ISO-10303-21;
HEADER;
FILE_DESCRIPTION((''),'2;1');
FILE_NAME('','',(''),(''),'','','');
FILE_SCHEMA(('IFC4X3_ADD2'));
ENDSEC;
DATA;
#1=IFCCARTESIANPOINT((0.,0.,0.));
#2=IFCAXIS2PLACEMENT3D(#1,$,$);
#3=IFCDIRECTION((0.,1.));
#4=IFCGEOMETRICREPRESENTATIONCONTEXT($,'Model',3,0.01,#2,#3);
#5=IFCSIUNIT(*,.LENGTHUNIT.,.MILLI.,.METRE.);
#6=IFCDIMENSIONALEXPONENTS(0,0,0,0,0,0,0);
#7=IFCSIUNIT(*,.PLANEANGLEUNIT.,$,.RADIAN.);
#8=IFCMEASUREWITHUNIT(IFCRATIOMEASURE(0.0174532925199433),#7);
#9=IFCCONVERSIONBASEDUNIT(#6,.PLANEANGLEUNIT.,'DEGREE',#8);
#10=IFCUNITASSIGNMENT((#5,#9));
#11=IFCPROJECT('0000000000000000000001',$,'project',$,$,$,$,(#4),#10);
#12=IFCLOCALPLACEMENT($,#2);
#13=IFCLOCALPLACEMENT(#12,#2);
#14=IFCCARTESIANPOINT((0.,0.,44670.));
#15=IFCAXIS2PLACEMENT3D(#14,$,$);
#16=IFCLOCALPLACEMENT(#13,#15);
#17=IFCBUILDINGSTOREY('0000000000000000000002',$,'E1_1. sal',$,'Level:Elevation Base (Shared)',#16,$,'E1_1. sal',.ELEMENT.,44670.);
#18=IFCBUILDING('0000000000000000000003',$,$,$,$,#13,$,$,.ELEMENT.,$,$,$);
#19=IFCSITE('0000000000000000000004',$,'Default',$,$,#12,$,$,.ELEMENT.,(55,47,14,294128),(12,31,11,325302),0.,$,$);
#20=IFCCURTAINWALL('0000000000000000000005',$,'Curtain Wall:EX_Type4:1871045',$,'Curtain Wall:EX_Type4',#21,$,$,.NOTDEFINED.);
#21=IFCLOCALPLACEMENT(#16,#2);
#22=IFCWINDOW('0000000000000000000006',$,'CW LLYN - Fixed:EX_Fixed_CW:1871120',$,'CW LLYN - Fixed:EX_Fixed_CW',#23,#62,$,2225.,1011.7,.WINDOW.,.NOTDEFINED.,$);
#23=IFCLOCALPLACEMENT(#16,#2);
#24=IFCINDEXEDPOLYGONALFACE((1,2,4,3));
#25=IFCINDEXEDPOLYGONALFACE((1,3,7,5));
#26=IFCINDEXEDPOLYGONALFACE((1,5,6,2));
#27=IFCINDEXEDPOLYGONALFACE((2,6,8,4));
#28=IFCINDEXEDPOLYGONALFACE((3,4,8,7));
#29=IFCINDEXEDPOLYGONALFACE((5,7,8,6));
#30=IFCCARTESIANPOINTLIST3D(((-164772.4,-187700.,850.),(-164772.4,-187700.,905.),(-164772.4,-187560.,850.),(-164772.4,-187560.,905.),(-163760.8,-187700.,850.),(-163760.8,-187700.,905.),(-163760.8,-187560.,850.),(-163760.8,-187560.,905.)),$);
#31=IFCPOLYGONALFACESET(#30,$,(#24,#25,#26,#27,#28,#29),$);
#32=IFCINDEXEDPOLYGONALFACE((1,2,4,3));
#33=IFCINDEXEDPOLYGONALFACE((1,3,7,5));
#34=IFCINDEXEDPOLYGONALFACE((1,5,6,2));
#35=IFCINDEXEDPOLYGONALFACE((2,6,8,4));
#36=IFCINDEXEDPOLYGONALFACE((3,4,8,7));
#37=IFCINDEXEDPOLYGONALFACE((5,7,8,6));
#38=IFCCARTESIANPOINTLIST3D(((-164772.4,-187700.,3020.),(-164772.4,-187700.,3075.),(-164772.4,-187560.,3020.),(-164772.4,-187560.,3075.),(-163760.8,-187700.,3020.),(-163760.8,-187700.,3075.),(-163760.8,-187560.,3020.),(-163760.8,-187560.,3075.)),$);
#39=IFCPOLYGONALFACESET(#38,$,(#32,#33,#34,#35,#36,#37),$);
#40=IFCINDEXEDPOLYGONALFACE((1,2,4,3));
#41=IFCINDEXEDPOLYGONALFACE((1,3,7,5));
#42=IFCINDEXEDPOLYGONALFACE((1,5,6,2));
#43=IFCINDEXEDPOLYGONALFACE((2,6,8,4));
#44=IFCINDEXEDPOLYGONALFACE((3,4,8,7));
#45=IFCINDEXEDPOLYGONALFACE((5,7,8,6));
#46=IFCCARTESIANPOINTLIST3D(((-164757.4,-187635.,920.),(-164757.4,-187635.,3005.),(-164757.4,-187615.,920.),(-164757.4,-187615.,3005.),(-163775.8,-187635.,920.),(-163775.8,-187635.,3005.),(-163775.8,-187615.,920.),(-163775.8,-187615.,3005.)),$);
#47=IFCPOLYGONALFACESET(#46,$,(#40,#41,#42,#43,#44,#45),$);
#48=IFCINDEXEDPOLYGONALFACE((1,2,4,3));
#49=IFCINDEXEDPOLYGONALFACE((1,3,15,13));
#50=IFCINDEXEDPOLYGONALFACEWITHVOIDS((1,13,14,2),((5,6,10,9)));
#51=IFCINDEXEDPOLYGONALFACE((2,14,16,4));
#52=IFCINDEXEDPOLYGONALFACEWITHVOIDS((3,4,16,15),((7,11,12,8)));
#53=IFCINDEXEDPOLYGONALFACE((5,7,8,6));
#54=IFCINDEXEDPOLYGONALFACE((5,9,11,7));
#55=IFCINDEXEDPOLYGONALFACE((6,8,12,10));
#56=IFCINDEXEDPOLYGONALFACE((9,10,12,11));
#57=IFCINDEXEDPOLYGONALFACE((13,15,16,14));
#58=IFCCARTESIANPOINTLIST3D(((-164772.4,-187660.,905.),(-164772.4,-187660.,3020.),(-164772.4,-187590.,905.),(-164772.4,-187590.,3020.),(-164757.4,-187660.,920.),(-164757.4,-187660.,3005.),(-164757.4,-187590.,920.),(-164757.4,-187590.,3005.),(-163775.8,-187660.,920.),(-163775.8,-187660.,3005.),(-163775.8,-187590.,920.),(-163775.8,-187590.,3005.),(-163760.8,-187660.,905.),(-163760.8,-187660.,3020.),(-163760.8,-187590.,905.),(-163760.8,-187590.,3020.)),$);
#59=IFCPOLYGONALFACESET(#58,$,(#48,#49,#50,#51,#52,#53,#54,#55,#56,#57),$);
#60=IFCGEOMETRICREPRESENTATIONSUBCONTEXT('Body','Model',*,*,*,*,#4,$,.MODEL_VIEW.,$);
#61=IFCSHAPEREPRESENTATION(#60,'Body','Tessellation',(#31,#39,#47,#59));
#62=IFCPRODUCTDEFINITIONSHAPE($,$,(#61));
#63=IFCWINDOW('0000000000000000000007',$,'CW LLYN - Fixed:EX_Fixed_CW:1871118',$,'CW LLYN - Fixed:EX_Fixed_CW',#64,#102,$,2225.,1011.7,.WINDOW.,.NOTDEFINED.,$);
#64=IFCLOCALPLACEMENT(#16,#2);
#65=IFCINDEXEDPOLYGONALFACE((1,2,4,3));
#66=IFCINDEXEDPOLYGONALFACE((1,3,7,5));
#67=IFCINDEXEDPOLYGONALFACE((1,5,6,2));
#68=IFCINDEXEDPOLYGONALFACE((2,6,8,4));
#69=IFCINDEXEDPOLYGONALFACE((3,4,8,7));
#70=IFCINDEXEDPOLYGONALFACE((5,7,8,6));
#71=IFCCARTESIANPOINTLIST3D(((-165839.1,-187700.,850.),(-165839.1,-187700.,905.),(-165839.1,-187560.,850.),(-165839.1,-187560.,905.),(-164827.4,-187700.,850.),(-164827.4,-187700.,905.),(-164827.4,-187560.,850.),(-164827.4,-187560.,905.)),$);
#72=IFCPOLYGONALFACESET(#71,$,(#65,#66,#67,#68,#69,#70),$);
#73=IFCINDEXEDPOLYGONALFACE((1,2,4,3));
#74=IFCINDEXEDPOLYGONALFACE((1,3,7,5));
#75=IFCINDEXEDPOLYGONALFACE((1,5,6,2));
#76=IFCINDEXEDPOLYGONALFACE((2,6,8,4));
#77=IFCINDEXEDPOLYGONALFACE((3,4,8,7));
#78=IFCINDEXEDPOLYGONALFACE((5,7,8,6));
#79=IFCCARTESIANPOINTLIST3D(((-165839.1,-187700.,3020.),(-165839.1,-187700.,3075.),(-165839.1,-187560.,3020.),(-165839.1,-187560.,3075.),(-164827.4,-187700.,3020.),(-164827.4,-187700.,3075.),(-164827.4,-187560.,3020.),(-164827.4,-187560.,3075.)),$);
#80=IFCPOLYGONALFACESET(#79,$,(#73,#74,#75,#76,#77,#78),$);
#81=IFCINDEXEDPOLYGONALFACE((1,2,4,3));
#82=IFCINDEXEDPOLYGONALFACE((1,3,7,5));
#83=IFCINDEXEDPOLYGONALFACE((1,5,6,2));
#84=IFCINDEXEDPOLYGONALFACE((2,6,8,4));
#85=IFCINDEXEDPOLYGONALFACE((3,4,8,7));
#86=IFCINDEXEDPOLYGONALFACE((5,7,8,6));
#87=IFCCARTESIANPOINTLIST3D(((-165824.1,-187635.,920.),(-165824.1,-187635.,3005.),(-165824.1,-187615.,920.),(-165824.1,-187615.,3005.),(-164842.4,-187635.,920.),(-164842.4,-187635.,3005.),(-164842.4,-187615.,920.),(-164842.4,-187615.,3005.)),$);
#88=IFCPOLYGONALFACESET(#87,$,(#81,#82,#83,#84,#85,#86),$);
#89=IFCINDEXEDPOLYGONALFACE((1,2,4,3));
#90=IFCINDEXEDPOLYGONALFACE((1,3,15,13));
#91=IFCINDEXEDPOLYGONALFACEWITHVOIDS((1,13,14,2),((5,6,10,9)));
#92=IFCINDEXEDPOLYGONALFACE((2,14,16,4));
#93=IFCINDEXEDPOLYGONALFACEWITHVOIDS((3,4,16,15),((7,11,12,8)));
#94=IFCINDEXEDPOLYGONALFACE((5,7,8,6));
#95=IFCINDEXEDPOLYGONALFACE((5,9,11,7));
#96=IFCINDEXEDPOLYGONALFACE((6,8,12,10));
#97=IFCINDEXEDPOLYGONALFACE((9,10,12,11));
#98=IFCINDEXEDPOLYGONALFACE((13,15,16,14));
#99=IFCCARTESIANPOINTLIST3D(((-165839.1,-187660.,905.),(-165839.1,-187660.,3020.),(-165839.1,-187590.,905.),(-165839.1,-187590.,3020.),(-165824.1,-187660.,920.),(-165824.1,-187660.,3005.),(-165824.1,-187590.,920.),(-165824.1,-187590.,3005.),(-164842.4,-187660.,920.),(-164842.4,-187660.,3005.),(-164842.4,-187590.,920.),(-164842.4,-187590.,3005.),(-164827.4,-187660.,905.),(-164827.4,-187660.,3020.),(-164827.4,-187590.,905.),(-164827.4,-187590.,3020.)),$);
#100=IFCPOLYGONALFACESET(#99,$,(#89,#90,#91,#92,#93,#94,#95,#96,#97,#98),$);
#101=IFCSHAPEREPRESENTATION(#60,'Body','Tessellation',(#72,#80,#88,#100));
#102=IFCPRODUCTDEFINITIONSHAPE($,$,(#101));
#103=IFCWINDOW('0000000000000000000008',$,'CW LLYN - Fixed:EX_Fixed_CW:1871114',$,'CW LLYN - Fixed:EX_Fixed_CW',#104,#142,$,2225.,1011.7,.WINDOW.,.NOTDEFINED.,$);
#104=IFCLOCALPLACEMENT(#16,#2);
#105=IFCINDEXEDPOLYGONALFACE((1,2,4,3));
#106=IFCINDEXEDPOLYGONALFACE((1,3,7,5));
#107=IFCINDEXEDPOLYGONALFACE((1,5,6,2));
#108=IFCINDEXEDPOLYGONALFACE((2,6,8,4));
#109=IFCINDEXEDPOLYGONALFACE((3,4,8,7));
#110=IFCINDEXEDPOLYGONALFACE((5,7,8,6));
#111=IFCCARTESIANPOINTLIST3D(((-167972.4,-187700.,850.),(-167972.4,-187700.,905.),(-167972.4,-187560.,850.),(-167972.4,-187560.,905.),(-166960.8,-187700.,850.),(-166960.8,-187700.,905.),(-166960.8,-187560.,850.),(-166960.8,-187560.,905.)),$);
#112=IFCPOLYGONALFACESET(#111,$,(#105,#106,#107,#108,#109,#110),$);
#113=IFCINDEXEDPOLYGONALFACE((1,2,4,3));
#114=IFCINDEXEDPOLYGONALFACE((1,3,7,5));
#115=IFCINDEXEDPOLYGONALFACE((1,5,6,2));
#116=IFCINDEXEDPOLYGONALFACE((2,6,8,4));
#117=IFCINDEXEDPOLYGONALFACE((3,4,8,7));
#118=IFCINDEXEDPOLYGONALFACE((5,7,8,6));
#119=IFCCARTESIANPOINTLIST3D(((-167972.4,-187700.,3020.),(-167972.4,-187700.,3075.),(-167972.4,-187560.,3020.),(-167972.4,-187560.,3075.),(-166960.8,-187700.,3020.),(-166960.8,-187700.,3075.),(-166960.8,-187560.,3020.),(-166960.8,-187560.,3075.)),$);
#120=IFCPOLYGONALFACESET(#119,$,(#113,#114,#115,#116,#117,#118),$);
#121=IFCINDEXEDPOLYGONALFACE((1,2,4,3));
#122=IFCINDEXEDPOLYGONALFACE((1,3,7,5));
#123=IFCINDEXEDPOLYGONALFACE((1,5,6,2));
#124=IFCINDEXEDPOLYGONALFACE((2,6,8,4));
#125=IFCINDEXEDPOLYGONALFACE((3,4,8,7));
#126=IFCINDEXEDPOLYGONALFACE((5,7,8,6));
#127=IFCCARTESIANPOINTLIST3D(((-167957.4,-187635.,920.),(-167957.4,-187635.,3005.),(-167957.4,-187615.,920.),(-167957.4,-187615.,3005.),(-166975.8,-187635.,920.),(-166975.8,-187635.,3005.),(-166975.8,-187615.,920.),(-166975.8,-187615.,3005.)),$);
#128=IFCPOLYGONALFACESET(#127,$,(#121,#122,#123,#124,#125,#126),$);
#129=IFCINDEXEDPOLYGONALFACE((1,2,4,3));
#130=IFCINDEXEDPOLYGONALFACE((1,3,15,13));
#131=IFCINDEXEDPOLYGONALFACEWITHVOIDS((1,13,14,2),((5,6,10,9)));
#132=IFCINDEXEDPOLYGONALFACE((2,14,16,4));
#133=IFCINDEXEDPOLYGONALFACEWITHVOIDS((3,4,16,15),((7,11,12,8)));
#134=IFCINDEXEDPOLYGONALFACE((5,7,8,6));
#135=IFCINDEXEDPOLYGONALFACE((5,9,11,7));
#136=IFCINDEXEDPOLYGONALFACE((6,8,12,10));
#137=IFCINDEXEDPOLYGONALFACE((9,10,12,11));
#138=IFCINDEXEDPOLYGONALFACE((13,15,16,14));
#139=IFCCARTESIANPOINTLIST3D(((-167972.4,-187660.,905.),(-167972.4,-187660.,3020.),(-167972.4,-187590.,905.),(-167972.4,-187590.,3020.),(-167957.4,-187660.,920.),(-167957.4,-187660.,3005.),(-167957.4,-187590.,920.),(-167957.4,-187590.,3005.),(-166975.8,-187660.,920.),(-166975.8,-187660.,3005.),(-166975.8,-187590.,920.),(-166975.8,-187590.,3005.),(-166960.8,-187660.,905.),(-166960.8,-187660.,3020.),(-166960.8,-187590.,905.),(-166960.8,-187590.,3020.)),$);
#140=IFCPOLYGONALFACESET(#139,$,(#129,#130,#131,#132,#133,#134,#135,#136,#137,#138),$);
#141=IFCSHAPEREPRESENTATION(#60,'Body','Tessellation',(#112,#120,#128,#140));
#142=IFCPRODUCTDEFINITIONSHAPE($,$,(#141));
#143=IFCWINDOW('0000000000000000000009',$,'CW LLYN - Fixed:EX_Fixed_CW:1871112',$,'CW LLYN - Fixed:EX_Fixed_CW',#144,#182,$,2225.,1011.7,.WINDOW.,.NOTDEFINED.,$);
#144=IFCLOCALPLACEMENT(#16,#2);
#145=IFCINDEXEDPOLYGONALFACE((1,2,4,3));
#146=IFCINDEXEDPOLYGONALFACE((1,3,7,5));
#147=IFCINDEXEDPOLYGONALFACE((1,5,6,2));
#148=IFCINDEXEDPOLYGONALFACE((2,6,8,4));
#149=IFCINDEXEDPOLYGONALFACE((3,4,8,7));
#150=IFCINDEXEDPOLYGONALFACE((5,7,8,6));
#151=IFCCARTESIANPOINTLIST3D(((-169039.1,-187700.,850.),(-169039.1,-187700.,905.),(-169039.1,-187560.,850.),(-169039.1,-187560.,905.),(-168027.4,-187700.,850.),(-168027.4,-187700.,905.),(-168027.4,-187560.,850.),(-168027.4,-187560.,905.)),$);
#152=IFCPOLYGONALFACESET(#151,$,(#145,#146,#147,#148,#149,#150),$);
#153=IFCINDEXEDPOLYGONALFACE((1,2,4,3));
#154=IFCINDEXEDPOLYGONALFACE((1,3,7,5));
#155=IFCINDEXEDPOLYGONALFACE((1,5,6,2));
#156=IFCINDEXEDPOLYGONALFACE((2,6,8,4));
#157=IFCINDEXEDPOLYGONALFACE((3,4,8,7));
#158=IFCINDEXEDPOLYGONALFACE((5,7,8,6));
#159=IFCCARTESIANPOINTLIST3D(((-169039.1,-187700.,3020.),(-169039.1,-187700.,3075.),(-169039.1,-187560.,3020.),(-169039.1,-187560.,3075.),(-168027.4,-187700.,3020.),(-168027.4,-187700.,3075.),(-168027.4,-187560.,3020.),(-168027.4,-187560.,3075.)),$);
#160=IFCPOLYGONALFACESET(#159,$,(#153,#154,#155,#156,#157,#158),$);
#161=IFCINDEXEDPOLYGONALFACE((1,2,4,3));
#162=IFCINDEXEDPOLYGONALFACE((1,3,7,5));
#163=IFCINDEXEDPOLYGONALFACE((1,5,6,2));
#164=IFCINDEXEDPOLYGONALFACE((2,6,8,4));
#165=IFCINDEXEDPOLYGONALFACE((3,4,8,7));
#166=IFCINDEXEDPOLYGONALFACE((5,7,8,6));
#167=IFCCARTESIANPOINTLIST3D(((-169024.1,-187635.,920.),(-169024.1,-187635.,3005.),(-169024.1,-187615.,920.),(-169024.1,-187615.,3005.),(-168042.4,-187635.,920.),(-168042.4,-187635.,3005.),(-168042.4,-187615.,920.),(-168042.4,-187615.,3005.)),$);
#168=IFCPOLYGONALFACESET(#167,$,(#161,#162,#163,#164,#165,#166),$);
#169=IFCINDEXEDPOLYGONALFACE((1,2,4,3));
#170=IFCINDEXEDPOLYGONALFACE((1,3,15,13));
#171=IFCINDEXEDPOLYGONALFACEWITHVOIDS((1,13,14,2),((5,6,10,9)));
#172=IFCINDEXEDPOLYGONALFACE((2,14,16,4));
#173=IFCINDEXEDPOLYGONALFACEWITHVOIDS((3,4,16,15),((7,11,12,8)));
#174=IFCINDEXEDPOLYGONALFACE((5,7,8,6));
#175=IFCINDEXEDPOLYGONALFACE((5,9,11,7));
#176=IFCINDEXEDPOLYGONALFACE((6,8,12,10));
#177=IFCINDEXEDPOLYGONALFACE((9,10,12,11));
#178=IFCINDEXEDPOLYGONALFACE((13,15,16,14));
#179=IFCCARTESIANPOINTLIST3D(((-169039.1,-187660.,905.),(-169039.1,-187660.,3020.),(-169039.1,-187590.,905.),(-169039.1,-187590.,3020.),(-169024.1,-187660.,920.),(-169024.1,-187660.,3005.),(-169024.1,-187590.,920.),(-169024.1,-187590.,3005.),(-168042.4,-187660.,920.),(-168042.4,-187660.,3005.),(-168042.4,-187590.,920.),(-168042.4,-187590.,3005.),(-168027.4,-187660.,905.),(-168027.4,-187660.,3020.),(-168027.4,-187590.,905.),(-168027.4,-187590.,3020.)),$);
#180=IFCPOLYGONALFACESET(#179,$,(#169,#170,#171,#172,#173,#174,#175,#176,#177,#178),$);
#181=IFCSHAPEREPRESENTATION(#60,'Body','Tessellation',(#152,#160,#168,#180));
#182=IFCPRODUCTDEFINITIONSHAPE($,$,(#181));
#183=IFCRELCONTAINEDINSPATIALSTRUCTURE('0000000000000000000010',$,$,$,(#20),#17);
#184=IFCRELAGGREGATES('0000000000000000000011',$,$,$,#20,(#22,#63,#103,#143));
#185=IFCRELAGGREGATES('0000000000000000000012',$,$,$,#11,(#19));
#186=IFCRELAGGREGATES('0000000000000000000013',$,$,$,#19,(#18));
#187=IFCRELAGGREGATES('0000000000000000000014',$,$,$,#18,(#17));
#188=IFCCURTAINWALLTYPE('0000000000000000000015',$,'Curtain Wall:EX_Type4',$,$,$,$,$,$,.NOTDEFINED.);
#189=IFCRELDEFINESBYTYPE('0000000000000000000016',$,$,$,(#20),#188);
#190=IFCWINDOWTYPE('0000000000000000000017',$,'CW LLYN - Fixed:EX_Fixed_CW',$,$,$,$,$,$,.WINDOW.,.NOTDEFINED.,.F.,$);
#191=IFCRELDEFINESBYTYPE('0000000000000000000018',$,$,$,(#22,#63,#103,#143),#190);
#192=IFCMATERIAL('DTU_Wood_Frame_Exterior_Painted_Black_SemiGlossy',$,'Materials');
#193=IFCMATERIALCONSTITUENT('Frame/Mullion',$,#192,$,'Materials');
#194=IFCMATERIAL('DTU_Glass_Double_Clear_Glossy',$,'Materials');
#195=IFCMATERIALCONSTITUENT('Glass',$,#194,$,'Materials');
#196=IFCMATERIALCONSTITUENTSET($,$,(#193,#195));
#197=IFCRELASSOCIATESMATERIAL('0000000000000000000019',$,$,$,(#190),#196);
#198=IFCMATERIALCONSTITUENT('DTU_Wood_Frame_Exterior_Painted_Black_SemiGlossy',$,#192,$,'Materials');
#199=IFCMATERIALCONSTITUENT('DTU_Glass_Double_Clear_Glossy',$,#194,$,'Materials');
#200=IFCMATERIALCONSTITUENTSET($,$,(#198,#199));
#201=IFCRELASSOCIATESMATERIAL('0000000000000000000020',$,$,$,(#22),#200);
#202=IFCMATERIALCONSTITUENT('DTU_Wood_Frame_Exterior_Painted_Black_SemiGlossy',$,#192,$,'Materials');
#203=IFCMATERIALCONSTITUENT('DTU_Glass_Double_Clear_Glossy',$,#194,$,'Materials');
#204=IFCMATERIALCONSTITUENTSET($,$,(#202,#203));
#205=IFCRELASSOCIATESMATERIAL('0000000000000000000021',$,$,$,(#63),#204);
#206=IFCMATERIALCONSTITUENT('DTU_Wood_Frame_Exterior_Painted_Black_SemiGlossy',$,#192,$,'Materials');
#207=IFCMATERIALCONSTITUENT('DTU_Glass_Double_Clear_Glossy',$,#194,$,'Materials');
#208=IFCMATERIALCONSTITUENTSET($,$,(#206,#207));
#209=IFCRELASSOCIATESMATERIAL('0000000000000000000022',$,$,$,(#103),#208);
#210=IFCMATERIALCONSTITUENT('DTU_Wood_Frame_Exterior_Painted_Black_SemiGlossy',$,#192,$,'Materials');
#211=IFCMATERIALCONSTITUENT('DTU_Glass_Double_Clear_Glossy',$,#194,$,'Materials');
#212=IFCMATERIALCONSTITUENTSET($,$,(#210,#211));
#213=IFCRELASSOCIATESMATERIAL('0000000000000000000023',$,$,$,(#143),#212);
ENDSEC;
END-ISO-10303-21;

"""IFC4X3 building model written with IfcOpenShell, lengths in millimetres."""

from ifc_helpers import new_model, entity, si_unit, converted_unit, direction, frame, frame_2d, origin, origin_2d_with_axis, place, context, subcontext, project, spatial, polyline, rectangle, outline, extrude, source, transform, mapped, material, constituent, constituent_set, type_object, type_shapes, element, aggregate, save


model = new_model("IFC4X3")

# Units and contexts
model_context = context("Model", 3, precision=0.01, world=origin(), true_north=direction((0.0, 1.0)))
body_context = subcontext(model_context, "Body", "Model", "MODEL_VIEW")
ifc_project = project(units=[si_unit("LENGTHUNIT", "METRE", prefix="MILLI"), converted_unit("PLANEANGLEUNIT", "DEGREE", entity("IfcRatioMeasure", 0.0174532925199433), si_unit("PLANEANGLEUNIT", "RADIAN"), dimensions=[0, 0, 0, 0, 0, 0, 0])], contexts=[model_context])

# Site, building, storey
site_placement = place(None, origin())
site = spatial("IfcSite", under=ifc_project, at=site_placement, Name="Default", CompositionType="ELEMENT", RefLatitude=(55, 47, 14, 294128), RefLongitude=(12, 31, 11, 325302), RefElevation=0.0)
building_placement = place(site_placement, origin())
building = spatial("IfcBuilding", under=site, at=building_placement, CompositionType="ELEMENT")
storey_placement = place(building_placement, frame((0.0, 0.0, 44670.0)))
storey = spatial("IfcBuildingStorey", under=building, at=storey_placement, Name="E1_1. sal", ObjectType="Level:Elevation Base (Shared)", LongName="E1_1. sal", CompositionType="ELEMENT", Elevation=44670.0)

# Curtain wall
curtain_wall_type = type_object("IfcCurtainWallType", Name="Curtain Wall:EX_Type4", PredefinedType="NOTDEFINED")
curtain_wall_placement = place(storey_placement, frame((0.0, 0.0, -44670.0)))
curtain_wall = element("IfcCurtainWall", 1, at=curtain_wall_placement, inside=storey, type_object=curtain_wall_type, Name="Curtain Wall:EX_Type4:1871045", ObjectType="Curtain Wall:EX_Type4", PredefinedType="NOTDEFINED")

# Windows
ifc_material_1 = material(Name="DTU_Wood_Frame_Exterior_Painted_Black_SemiGlossy", Category="Materials")
ifc_constituent_1 = constituent(ifc_material_1, Name="DTU_Wood_Frame_Exterior_Painted_Black_SemiGlossy", Category="Materials")
ifc_material_2 = material(Name="DTU_Glass_Double_Clear_Glossy", Category="Materials")
ifc_constituent_2 = constituent(ifc_material_2, Name="DTU_Glass_Double_Clear_Glossy", Category="Materials")
ifc_constituent_set_1 = constituent_set(constituents=[ifc_constituent_1, ifc_constituent_2])
ifc_constituent_3 = constituent(ifc_material_1, Name="Frame/Mullion", Category="Materials")
ifc_constituent_4 = constituent(ifc_material_2, Name="Glass", Category="Materials")
ifc_constituent_set_2 = constituent_set(constituents=[ifc_constituent_3, ifc_constituent_4])
window_type_1 = type_object("IfcWindowType", Name="CW LLYN - Fixed:EX_Fixed_CW", ParameterTakesPrecedence=False, PartitioningType="NOTDEFINED", PredefinedType="WINDOW", material=ifc_constituent_set_2)
shared_shape_1 = source(origin(), body_context, "Body", "SweptSolid", [
    extrude(rectangle(XDim=140.0, YDim=1011.7, at=origin_2d_with_axis()), frame((0.0, -130.0, 0.0), z_axis=(0.0, 0.0, 1.0), x_axis=(0.0, -1.0, 0.0)), (0.0, 0.0, 1.0), 55.0),
    extrude(rectangle(XDim=140.0, YDim=1011.7, at=frame_2d((0.0, 0.0), x_axis=(1.0, 0.0))), frame((0.0, -130.0, 2170.0), z_axis=(0.0, 0.0, 1.0), x_axis=(0.0, -1.0, 0.0)), (0.0, 0.0, 1.0), 55.0),
    extrude(rectangle(XDim=981.7, YDim=20.0, at=frame_2d((0.0, 0.0), x_axis=(1.0, 0.0))), frame((0.0, -125.0, 70.0), z_axis=(0.0, 0.0, 1.0), x_axis=(-1.0, 0.0, 0.0)), (0.0, 0.0, 1.0), 2085.0),
    extrude(outline(polyline([(-1057.5, -505.8), (1057.5, -505.8), (1057.5, 505.8), (-1057.5, 505.8), (-1057.5, -505.8)]), holes=[polyline([(-1042.5, 490.8), (1042.5, 490.8), (1042.5, -490.8), (-1042.5, -490.8), (-1042.5, 490.8)])]), frame((0.0, -90.0, 1112.5), z_axis=(0.0, -1.0, 0.0), x_axis=(0.0, 0.0, 1.0)), (0.0, 0.0, 1.0), 70.0),
])
type_shapes(window_type_1, [shared_shape_1])
window_1_placement = place(curtain_wall_placement, frame((-164266.6, -187500.0, 45520.0)))
window_1 = element("IfcWindow", 2, at=window_1_placement, type_object=window_type_1, material=ifc_constituent_set_1, Name="CW LLYN - Fixed:EX_Fixed_CW:1871120", ObjectType="CW LLYN - Fixed:EX_Fixed_CW", OverallHeight=2225.0, OverallWidth=1011.7, PartitioningType="NOTDEFINED", PredefinedType="WINDOW", context=body_context, shape_type="MappedRepresentation", body=[
    mapped(shared_shape_1, transform((0.0, 0.0, 0.0), scale=1.0)),
])
ifc_constituent_5 = constituent(ifc_material_1, Name="DTU_Wood_Frame_Exterior_Painted_Black_SemiGlossy", Category="Materials")
ifc_constituent_6 = constituent(ifc_material_2, Name="DTU_Glass_Double_Clear_Glossy", Category="Materials")
ifc_constituent_set_3 = constituent_set(constituents=[ifc_constituent_5, ifc_constituent_6])
window_2_placement = place(curtain_wall_placement, frame((-165333.3, -187500.0, 45520.0)))
window_2 = element("IfcWindow", 3, at=window_2_placement, type_object=window_type_1, material=ifc_constituent_set_3, Name="CW LLYN - Fixed:EX_Fixed_CW:1871118", ObjectType="CW LLYN - Fixed:EX_Fixed_CW", OverallHeight=2225.0, OverallWidth=1011.7, PartitioningType="NOTDEFINED", PredefinedType="WINDOW", context=body_context, shape_type="MappedRepresentation", body=[
    mapped(shared_shape_1, transform((0.0, 0.0, 0.0), scale=1.0)),
])
ifc_constituent_7 = constituent(ifc_material_1, Name="DTU_Wood_Frame_Exterior_Painted_Black_SemiGlossy", Category="Materials")
ifc_constituent_8 = constituent(ifc_material_2, Name="DTU_Glass_Double_Clear_Glossy", Category="Materials")
ifc_constituent_set_4 = constituent_set(constituents=[ifc_constituent_7, ifc_constituent_8])
window_3_placement = place(curtain_wall_placement, frame((-167466.6, -187500.0, 45520.0)))
window_3 = element("IfcWindow", 4, at=window_3_placement, type_object=window_type_1, material=ifc_constituent_set_4, Name="CW LLYN - Fixed:EX_Fixed_CW:1871114", ObjectType="CW LLYN - Fixed:EX_Fixed_CW", OverallHeight=2225.0, OverallWidth=1011.7, PartitioningType="NOTDEFINED", PredefinedType="WINDOW", context=body_context, shape_type="MappedRepresentation", body=[
    mapped(shared_shape_1, transform((0.0, 0.0, 0.0), scale=1.0)),
])
ifc_constituent_9 = constituent(ifc_material_1, Name="DTU_Wood_Frame_Exterior_Painted_Black_SemiGlossy", Category="Materials")
ifc_constituent_10 = constituent(ifc_material_2, Name="DTU_Glass_Double_Clear_Glossy", Category="Materials")
ifc_constituent_set_5 = constituent_set(constituents=[ifc_constituent_9, ifc_constituent_10])
window_4_placement = place(curtain_wall_placement, frame((-168533.3, -187500.0, 45520.0)))
window_4 = element("IfcWindow", 5, at=window_4_placement, type_object=window_type_1, material=ifc_constituent_set_5, Name="CW LLYN - Fixed:EX_Fixed_CW:1871112", ObjectType="CW LLYN - Fixed:EX_Fixed_CW", OverallHeight=2225.0, OverallWidth=1011.7, PartitioningType="NOTDEFINED", PredefinedType="WINDOW", context=body_context, shape_type="MappedRepresentation", body=[
    mapped(shared_shape_1, transform((0.0, 0.0, 0.0), scale=1.0)),
])

aggregate(curtain_wall, [window_1, window_2, window_3, window_4])

save(model, "model.ifc")
